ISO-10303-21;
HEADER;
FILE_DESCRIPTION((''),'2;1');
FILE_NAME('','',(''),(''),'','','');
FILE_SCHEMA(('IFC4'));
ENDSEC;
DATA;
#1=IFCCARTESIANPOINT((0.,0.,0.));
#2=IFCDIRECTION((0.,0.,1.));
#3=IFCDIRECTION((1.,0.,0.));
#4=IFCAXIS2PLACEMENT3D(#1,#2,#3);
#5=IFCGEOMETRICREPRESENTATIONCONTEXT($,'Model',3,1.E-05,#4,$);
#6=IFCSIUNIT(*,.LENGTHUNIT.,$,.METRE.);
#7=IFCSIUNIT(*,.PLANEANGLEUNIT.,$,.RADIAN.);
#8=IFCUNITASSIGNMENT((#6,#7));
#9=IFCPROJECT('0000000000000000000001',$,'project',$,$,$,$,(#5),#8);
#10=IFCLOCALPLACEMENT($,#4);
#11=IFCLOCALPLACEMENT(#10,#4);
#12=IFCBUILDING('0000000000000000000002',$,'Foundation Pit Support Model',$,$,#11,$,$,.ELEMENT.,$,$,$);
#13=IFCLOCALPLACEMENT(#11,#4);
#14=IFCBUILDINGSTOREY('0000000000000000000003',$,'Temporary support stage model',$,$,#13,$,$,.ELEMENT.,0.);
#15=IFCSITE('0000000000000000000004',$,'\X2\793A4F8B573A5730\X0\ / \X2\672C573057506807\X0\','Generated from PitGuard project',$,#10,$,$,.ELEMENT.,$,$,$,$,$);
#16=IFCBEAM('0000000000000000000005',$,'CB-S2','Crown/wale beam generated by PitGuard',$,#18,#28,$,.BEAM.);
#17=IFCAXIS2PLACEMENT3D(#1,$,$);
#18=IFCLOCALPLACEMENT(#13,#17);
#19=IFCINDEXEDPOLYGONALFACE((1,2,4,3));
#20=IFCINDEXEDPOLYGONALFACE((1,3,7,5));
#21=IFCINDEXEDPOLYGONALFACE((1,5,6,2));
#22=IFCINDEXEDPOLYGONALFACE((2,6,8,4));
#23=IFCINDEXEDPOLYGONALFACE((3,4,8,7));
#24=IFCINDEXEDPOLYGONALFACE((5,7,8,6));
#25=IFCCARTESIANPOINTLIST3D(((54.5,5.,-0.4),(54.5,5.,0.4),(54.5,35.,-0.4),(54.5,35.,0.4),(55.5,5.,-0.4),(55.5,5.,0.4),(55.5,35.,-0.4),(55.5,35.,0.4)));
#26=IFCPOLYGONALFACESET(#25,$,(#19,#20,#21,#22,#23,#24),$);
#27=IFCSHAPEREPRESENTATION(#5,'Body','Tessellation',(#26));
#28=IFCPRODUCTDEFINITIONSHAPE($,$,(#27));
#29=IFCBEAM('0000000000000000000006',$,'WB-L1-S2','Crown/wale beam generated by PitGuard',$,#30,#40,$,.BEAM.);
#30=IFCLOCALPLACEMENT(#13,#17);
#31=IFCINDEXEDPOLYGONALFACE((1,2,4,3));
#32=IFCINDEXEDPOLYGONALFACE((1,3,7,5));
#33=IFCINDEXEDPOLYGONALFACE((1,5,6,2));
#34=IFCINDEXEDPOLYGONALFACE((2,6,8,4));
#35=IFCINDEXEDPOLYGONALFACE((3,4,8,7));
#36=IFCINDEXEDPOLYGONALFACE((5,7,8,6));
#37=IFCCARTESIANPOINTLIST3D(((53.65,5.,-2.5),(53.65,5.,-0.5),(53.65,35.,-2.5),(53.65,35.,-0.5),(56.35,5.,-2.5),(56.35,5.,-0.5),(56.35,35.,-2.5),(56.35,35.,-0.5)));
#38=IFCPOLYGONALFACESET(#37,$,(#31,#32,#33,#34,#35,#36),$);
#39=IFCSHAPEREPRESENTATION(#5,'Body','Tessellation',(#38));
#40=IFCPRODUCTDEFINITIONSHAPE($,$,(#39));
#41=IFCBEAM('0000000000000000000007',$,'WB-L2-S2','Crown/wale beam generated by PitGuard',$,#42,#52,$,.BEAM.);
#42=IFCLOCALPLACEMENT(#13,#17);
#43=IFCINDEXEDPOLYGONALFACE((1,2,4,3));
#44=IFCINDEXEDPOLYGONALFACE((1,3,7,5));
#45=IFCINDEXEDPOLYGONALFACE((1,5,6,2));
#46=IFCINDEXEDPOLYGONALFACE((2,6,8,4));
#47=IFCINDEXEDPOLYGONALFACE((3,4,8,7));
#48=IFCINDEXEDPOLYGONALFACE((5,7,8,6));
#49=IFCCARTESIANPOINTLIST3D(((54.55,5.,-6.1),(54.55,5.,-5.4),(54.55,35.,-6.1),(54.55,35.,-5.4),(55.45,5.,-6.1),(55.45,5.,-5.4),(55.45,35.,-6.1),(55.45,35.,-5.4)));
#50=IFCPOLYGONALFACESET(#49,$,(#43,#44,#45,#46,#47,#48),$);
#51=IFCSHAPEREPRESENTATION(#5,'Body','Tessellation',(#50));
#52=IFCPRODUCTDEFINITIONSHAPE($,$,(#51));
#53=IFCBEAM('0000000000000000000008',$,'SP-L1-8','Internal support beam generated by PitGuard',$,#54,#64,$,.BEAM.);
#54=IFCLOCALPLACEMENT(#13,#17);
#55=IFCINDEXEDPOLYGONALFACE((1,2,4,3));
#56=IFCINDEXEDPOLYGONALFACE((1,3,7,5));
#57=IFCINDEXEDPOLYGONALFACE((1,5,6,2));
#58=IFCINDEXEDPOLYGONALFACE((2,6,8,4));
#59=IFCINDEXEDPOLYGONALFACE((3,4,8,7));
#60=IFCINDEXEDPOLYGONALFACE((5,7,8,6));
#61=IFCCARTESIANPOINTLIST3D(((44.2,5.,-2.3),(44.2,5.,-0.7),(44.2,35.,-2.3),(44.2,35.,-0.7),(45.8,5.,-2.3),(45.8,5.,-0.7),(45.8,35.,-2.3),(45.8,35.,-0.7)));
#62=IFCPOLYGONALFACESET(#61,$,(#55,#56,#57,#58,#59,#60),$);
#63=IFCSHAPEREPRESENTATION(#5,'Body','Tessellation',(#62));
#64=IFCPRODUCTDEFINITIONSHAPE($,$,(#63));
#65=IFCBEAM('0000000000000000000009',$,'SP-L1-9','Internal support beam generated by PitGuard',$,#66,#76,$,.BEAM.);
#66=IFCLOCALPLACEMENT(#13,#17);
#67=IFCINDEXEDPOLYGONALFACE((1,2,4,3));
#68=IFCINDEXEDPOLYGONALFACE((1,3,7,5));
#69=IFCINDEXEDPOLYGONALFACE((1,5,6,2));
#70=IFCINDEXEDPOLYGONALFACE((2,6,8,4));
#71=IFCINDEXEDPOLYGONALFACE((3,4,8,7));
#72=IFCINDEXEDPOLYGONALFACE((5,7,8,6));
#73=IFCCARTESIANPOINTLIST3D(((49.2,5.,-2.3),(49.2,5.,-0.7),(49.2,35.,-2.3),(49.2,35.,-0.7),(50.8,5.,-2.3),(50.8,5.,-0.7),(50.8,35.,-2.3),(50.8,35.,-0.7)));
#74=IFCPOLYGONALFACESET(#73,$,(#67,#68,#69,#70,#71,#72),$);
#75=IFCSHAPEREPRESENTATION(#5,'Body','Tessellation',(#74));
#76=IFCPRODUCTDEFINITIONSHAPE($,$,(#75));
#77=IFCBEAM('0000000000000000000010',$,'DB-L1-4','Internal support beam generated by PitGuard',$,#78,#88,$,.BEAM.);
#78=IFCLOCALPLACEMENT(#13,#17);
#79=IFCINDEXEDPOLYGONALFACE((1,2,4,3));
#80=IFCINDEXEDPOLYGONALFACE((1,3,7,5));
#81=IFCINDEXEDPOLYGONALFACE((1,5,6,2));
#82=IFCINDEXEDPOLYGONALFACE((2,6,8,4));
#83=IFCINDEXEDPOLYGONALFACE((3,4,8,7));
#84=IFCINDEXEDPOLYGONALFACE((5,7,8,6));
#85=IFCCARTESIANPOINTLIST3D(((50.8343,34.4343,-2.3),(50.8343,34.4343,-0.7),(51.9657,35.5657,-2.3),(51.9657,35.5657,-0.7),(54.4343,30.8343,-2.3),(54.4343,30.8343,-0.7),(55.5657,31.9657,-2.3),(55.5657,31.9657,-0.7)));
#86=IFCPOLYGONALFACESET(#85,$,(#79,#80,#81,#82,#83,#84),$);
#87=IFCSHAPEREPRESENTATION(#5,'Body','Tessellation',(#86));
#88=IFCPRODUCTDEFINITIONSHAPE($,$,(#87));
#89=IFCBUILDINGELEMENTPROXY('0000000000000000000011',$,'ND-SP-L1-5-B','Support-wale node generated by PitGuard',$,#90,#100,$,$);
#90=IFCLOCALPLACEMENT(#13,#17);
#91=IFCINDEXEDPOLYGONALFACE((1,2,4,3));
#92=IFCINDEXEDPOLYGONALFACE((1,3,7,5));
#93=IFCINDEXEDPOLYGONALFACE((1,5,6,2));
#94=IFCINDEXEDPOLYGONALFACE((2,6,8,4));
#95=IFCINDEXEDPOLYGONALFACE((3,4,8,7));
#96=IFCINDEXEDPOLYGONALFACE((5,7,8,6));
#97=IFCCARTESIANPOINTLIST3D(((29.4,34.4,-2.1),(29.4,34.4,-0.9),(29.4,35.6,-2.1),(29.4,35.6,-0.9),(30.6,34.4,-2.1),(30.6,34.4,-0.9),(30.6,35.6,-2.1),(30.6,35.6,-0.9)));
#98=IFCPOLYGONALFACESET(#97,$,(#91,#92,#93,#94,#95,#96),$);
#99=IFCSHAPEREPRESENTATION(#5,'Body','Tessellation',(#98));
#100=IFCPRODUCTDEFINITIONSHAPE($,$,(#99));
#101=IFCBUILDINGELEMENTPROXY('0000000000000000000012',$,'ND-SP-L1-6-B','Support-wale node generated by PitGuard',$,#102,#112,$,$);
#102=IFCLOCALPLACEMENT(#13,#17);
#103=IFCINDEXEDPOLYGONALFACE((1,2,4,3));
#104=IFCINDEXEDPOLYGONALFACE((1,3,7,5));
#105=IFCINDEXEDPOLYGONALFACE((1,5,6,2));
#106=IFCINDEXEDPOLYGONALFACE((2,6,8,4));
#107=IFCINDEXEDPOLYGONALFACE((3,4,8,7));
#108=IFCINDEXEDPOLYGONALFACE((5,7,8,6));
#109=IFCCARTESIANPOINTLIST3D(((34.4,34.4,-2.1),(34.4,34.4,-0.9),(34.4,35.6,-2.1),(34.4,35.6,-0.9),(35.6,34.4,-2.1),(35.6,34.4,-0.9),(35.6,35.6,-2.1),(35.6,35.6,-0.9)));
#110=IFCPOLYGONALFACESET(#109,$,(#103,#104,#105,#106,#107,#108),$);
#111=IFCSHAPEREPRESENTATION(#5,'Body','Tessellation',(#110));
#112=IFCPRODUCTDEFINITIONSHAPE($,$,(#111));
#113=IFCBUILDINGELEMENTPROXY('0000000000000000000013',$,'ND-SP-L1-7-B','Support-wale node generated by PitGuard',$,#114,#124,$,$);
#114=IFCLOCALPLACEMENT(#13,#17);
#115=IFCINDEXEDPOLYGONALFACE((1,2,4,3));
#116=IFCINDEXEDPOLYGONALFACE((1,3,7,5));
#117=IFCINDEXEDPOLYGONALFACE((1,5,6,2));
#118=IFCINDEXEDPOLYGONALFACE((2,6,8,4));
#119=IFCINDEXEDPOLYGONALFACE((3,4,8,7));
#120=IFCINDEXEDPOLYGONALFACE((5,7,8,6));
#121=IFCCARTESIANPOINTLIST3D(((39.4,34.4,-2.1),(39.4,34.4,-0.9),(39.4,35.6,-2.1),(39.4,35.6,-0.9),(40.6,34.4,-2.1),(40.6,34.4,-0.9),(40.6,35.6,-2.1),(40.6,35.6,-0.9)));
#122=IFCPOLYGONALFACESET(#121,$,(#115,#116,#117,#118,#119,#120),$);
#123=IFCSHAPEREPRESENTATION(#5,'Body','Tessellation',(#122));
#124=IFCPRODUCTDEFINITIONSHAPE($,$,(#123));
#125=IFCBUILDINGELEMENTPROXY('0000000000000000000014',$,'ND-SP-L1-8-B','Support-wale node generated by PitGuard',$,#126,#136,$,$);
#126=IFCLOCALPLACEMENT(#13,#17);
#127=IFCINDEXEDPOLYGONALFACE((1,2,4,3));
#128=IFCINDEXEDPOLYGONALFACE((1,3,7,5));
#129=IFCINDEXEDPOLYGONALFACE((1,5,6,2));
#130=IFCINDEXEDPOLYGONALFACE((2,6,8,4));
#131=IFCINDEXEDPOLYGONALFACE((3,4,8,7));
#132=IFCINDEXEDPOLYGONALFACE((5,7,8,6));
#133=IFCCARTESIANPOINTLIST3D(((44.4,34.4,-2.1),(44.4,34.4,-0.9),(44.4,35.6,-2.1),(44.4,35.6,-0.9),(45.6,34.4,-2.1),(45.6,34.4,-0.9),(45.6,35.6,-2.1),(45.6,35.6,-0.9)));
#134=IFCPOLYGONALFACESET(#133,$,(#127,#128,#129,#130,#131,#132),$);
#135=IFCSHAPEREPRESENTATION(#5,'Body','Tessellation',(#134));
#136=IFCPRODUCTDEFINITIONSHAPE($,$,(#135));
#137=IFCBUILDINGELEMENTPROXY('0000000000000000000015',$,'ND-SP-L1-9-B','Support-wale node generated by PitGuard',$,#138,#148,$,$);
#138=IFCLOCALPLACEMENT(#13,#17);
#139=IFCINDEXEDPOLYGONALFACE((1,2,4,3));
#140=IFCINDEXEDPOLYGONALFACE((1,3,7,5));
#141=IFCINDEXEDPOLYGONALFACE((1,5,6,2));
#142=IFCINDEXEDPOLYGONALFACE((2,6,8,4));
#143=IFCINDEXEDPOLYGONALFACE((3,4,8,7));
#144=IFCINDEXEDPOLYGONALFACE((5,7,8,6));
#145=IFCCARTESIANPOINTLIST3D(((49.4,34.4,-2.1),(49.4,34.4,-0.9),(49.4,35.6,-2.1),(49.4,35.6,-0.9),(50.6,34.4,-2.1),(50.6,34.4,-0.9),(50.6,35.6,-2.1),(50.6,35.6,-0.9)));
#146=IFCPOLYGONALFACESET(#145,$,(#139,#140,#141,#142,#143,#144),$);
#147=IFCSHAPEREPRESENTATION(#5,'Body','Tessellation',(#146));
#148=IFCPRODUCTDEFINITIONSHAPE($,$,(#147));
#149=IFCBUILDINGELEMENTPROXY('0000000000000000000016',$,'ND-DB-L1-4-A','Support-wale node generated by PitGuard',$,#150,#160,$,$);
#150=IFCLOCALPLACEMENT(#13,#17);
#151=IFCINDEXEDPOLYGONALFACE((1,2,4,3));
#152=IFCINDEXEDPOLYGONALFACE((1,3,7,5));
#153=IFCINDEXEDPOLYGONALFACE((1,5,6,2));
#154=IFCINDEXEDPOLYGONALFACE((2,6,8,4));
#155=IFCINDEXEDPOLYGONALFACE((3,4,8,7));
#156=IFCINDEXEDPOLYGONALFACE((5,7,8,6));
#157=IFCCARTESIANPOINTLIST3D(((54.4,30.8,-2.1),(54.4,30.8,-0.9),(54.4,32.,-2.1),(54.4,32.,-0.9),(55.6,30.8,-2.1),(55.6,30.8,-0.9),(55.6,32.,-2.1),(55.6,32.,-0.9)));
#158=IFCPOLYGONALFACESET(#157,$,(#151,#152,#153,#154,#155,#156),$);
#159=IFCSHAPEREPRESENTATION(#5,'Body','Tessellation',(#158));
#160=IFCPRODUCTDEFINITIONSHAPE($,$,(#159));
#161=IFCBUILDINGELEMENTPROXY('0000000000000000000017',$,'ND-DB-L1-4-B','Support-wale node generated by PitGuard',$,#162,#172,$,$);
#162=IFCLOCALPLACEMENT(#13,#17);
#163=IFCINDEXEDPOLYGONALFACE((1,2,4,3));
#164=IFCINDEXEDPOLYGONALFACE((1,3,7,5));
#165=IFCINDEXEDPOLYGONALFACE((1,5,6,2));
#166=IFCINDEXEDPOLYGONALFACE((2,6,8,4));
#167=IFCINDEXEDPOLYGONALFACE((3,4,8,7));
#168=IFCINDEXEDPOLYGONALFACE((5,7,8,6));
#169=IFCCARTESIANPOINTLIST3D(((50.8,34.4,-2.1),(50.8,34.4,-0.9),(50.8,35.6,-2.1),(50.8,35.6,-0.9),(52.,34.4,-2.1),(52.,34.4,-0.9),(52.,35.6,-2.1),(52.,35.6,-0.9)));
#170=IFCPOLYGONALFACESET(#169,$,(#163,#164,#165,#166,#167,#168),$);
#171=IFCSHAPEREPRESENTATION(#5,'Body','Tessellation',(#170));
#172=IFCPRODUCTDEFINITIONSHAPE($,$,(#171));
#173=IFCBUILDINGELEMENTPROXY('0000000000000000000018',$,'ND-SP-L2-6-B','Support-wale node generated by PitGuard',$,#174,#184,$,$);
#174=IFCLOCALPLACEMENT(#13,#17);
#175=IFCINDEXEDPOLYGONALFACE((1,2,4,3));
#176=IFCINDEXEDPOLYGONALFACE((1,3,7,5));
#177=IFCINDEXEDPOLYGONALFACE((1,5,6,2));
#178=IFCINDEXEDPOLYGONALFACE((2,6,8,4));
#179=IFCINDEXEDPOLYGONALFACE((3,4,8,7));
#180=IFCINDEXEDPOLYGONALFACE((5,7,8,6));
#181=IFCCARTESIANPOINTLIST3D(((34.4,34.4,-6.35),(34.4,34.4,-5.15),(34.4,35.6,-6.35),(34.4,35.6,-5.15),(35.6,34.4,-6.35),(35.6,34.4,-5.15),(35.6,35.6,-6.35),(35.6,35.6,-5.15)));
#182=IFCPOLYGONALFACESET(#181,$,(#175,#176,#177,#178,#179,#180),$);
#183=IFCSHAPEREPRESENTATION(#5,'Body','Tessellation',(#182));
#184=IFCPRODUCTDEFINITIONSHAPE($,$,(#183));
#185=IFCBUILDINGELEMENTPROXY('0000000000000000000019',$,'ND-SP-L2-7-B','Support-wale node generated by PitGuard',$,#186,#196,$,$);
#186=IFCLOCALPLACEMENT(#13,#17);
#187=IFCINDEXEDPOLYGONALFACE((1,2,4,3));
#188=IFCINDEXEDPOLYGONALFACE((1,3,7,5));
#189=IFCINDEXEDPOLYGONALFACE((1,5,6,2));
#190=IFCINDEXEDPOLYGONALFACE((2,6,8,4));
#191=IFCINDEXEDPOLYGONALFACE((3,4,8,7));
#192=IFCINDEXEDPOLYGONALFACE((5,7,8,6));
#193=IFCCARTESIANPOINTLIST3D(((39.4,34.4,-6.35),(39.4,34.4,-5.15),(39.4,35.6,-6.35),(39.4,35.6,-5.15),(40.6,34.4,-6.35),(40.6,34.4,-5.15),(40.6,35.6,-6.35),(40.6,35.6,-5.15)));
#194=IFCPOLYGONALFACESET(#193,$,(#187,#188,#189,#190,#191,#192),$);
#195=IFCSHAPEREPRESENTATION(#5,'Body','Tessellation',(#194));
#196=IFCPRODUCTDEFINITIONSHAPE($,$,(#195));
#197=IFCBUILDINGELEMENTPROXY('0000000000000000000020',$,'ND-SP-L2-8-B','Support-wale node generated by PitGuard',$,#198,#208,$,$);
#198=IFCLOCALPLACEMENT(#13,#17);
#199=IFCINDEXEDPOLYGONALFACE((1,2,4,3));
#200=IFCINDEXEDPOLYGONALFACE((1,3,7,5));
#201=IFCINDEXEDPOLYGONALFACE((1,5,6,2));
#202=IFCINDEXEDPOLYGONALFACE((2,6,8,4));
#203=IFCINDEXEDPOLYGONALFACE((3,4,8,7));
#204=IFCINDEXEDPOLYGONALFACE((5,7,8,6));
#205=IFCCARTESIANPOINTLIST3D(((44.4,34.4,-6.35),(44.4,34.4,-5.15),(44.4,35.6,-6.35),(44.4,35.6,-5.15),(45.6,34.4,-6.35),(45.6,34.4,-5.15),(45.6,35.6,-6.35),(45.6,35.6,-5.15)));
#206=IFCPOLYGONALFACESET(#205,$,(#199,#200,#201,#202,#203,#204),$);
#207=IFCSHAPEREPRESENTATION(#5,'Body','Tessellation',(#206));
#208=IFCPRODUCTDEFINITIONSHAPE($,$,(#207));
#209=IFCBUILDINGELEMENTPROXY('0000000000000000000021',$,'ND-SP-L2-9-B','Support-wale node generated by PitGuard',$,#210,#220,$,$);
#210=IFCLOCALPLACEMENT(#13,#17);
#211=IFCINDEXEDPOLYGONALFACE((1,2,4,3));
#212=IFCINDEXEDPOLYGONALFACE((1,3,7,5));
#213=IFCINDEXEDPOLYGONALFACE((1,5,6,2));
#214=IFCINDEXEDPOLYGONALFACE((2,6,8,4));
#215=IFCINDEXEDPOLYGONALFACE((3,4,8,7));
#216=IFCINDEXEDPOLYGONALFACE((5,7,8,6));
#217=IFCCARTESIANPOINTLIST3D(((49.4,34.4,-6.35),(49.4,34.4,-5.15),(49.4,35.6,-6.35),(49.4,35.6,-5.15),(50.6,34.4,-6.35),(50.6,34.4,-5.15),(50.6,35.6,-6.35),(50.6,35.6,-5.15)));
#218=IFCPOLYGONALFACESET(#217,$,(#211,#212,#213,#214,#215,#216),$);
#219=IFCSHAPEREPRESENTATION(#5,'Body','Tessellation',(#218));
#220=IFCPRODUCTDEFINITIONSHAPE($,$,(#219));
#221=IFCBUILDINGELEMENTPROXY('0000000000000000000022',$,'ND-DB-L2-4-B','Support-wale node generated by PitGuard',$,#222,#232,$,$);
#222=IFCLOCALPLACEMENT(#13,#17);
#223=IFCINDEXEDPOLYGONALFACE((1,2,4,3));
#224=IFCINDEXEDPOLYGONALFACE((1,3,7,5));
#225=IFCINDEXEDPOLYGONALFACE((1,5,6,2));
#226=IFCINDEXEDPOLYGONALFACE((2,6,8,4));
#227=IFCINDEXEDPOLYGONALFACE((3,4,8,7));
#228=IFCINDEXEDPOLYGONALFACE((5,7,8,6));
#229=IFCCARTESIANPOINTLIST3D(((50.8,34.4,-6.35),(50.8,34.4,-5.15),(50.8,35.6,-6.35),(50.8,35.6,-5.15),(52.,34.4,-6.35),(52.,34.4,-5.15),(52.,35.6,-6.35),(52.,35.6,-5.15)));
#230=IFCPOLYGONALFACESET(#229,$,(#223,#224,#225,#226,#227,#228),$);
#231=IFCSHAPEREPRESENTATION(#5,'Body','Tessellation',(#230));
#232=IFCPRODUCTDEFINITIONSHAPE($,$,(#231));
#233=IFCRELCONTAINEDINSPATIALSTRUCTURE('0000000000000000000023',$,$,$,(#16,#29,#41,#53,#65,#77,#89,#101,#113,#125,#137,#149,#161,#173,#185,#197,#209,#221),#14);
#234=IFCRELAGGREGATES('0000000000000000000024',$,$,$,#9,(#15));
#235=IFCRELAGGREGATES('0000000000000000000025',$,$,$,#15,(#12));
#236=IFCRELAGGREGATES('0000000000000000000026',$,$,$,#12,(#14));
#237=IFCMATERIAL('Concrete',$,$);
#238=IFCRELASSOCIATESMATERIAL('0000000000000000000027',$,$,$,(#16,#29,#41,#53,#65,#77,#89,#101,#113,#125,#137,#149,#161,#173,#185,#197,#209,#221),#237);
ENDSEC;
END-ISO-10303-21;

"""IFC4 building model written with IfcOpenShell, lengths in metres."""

from ifc_helpers import new_model, si_unit, frame, origin_with_axes, origin_2d, place, context, project, spatial, rectangle, extrude, material, element, save


model = new_model("IFC4")

# Units and contexts
model_context = context("Model", 3, precision=1e-05, world=origin_with_axes())
ifc_project = project(units=[si_unit("LENGTHUNIT", "METRE"), si_unit("PLANEANGLEUNIT", "RADIAN")], contexts=[model_context])

# Site, building, storey
site_placement = place(None, origin_with_axes())
site = spatial("IfcSite", under=ifc_project, at=site_placement, Name="示例场地 / 本地坐标", Description="Generated from PitGuard project", CompositionType="ELEMENT")
building_placement = place(site_placement, origin_with_axes())
building = spatial("IfcBuilding", under=site, at=building_placement, Name="Foundation Pit Support Model", CompositionType="ELEMENT")
storey_placement = place(building_placement, origin_with_axes())
storey = spatial("IfcBuildingStorey", under=building, at=storey_placement, Name="Temporary support stage model", CompositionType="ELEMENT", Elevation=0.0)

# Beams
ifc_material_1 = material(Name="Concrete")
beam_1_placement = place(storey_placement, frame((55.0, 20.0, -0.4), z_axis=(0.0, 0.0, 1.0), x_axis=(0.0, 1.0, 0.0)))
element("IfcBeam", 1, at=beam_1_placement, inside=storey, material=ifc_material_1, Name="CB-S2", Description="Crown/wale beam generated by PitGuard", PredefinedType="BEAM", context=model_context, shape_type="SweptSolid", body=[
    extrude(rectangle(XDim=30.0, YDim=1.0, at=origin_2d()), origin_with_axes(), (0.0, 0.0, 1.0), 0.8),
])
beam_2_placement = place(storey_placement, frame((55.0, 20.0, -2.5), z_axis=(0.0, 0.0, 1.0), x_axis=(0.0, 1.0, 0.0)))
element("IfcBeam", 2, at=beam_2_placement, inside=storey, material=ifc_material_1, Name="WB-L1-S2", Description="Crown/wale beam generated by PitGuard", PredefinedType="BEAM", context=model_context, shape_type="SweptSolid", body=[
    extrude(rectangle(XDim=30.0, YDim=2.7, at=origin_2d()), origin_with_axes(), (0.0, 0.0, 1.0), 2.0),
])
beam_3_placement = place(storey_placement, frame((55.0, 20.0, -6.1), z_axis=(0.0, 0.0, 1.0), x_axis=(0.0, 1.0, 0.0)))
element("IfcBeam", 3, at=beam_3_placement, inside=storey, material=ifc_material_1, Name="WB-L2-S2", Description="Crown/wale beam generated by PitGuard", PredefinedType="BEAM", context=model_context, shape_type="SweptSolid", body=[
    extrude(rectangle(XDim=30.0, YDim=0.9, at=origin_2d()), origin_with_axes(), (0.0, 0.0, 1.0), 0.7),
])
for number, where, z_axis, x_axis, name in (
    (4, (45.0, 20.0, -2.3), (0.0, 0.0, 1.0), (0.0, 1.0, 0.0), "SP-L1-8"),
    (5, (50.0, 20.0, -2.3), (0.0, 0.0, 1.0), (0.0, 1.0, 0.0), "SP-L1-9"),
):
    element("IfcBeam", number, at=place(storey_placement, frame(where, z_axis=z_axis, x_axis=x_axis)), inside=storey, material=ifc_material_1, Name=name, Description="Internal support beam generated by PitGuard", PredefinedType="BEAM", context=model_context, shape_type="SweptSolid", body=[
        extrude(rectangle(XDim=30.0, YDim=1.6, at=origin_2d()), origin_with_axes(), (0.0, 0.0, 1.0), 1.6),
    ])
beam_4_placement = place(storey_placement, frame((53.2, 33.2, -2.3), z_axis=(0.0, 0.0, 1.0), x_axis=(-0.707107, 0.707107, 0.0)))
element("IfcBeam", 6, at=beam_4_placement, inside=storey, material=ifc_material_1, Name="DB-L1-4", Description="Internal support beam generated by PitGuard", PredefinedType="BEAM", context=model_context, shape_type="SweptSolid", body=[
    extrude(rectangle(XDim=5.0912, YDim=1.6, at=origin_2d()), origin_with_axes(), (0.0, 0.0, 1.0), 1.6),
])

# Building element proxies
for number, where, z_axis, x_axis, name in (
    (7, (30.0, 35.0, -2.1), (0.0, 0.0, 1.0), (1.0, 0.0, 0.0), "ND-SP-L1-5-B"),
    (8, (35.0, 35.0, -2.1), (0.0, 0.0, 1.0), (1.0, 0.0, 0.0), "ND-SP-L1-6-B"),
    (9, (40.0, 35.0, -2.1), (0.0, 0.0, 1.0), (1.0, 0.0, 0.0), "ND-SP-L1-7-B"),
    (10, (45.0, 35.0, -2.1), (0.0, 0.0, 1.0), (1.0, 0.0, 0.0), "ND-SP-L1-8-B"),
    (11, (50.0, 35.0, -2.1), (0.0, 0.0, 1.0), (1.0, 0.0, 0.0), "ND-SP-L1-9-B"),
    (12, (55.0, 31.4, -2.1), (0.0, 0.0, 1.0), (1.0, 0.0, 0.0), "ND-DB-L1-4-A"),
    (13, (51.4, 35.0, -2.1), (0.0, 0.0, 1.0), (1.0, 0.0, 0.0), "ND-DB-L1-4-B"),
    (14, (35.0, 35.0, -6.35), (0.0, 0.0, 1.0), (1.0, 0.0, 0.0), "ND-SP-L2-6-B"),
    (15, (40.0, 35.0, -6.35), (0.0, 0.0, 1.0), (1.0, 0.0, 0.0), "ND-SP-L2-7-B"),
    (16, (45.0, 35.0, -6.35), (0.0, 0.0, 1.0), (1.0, 0.0, 0.0), "ND-SP-L2-8-B"),
    (17, (50.0, 35.0, -6.35), (0.0, 0.0, 1.0), (1.0, 0.0, 0.0), "ND-SP-L2-9-B"),
    (18, (51.4, 35.0, -6.35), (0.0, 0.0, 1.0), (1.0, 0.0, 0.0), "ND-DB-L2-4-B"),
):
    element("IfcBuildingElementProxy", number, at=place(storey_placement, frame(where, z_axis=z_axis, x_axis=x_axis)), inside=storey, material=ifc_material_1, Name=name, Description="Support-wale node generated by PitGuard", context=model_context, shape_type="SweptSolid", body=[
        extrude(rectangle(XDim=1.2, YDim=1.2, at=origin_2d()), origin_with_axes(), (0.0, 0.0, 1.0), 1.2),
    ])

save(model, "model.ifc")
